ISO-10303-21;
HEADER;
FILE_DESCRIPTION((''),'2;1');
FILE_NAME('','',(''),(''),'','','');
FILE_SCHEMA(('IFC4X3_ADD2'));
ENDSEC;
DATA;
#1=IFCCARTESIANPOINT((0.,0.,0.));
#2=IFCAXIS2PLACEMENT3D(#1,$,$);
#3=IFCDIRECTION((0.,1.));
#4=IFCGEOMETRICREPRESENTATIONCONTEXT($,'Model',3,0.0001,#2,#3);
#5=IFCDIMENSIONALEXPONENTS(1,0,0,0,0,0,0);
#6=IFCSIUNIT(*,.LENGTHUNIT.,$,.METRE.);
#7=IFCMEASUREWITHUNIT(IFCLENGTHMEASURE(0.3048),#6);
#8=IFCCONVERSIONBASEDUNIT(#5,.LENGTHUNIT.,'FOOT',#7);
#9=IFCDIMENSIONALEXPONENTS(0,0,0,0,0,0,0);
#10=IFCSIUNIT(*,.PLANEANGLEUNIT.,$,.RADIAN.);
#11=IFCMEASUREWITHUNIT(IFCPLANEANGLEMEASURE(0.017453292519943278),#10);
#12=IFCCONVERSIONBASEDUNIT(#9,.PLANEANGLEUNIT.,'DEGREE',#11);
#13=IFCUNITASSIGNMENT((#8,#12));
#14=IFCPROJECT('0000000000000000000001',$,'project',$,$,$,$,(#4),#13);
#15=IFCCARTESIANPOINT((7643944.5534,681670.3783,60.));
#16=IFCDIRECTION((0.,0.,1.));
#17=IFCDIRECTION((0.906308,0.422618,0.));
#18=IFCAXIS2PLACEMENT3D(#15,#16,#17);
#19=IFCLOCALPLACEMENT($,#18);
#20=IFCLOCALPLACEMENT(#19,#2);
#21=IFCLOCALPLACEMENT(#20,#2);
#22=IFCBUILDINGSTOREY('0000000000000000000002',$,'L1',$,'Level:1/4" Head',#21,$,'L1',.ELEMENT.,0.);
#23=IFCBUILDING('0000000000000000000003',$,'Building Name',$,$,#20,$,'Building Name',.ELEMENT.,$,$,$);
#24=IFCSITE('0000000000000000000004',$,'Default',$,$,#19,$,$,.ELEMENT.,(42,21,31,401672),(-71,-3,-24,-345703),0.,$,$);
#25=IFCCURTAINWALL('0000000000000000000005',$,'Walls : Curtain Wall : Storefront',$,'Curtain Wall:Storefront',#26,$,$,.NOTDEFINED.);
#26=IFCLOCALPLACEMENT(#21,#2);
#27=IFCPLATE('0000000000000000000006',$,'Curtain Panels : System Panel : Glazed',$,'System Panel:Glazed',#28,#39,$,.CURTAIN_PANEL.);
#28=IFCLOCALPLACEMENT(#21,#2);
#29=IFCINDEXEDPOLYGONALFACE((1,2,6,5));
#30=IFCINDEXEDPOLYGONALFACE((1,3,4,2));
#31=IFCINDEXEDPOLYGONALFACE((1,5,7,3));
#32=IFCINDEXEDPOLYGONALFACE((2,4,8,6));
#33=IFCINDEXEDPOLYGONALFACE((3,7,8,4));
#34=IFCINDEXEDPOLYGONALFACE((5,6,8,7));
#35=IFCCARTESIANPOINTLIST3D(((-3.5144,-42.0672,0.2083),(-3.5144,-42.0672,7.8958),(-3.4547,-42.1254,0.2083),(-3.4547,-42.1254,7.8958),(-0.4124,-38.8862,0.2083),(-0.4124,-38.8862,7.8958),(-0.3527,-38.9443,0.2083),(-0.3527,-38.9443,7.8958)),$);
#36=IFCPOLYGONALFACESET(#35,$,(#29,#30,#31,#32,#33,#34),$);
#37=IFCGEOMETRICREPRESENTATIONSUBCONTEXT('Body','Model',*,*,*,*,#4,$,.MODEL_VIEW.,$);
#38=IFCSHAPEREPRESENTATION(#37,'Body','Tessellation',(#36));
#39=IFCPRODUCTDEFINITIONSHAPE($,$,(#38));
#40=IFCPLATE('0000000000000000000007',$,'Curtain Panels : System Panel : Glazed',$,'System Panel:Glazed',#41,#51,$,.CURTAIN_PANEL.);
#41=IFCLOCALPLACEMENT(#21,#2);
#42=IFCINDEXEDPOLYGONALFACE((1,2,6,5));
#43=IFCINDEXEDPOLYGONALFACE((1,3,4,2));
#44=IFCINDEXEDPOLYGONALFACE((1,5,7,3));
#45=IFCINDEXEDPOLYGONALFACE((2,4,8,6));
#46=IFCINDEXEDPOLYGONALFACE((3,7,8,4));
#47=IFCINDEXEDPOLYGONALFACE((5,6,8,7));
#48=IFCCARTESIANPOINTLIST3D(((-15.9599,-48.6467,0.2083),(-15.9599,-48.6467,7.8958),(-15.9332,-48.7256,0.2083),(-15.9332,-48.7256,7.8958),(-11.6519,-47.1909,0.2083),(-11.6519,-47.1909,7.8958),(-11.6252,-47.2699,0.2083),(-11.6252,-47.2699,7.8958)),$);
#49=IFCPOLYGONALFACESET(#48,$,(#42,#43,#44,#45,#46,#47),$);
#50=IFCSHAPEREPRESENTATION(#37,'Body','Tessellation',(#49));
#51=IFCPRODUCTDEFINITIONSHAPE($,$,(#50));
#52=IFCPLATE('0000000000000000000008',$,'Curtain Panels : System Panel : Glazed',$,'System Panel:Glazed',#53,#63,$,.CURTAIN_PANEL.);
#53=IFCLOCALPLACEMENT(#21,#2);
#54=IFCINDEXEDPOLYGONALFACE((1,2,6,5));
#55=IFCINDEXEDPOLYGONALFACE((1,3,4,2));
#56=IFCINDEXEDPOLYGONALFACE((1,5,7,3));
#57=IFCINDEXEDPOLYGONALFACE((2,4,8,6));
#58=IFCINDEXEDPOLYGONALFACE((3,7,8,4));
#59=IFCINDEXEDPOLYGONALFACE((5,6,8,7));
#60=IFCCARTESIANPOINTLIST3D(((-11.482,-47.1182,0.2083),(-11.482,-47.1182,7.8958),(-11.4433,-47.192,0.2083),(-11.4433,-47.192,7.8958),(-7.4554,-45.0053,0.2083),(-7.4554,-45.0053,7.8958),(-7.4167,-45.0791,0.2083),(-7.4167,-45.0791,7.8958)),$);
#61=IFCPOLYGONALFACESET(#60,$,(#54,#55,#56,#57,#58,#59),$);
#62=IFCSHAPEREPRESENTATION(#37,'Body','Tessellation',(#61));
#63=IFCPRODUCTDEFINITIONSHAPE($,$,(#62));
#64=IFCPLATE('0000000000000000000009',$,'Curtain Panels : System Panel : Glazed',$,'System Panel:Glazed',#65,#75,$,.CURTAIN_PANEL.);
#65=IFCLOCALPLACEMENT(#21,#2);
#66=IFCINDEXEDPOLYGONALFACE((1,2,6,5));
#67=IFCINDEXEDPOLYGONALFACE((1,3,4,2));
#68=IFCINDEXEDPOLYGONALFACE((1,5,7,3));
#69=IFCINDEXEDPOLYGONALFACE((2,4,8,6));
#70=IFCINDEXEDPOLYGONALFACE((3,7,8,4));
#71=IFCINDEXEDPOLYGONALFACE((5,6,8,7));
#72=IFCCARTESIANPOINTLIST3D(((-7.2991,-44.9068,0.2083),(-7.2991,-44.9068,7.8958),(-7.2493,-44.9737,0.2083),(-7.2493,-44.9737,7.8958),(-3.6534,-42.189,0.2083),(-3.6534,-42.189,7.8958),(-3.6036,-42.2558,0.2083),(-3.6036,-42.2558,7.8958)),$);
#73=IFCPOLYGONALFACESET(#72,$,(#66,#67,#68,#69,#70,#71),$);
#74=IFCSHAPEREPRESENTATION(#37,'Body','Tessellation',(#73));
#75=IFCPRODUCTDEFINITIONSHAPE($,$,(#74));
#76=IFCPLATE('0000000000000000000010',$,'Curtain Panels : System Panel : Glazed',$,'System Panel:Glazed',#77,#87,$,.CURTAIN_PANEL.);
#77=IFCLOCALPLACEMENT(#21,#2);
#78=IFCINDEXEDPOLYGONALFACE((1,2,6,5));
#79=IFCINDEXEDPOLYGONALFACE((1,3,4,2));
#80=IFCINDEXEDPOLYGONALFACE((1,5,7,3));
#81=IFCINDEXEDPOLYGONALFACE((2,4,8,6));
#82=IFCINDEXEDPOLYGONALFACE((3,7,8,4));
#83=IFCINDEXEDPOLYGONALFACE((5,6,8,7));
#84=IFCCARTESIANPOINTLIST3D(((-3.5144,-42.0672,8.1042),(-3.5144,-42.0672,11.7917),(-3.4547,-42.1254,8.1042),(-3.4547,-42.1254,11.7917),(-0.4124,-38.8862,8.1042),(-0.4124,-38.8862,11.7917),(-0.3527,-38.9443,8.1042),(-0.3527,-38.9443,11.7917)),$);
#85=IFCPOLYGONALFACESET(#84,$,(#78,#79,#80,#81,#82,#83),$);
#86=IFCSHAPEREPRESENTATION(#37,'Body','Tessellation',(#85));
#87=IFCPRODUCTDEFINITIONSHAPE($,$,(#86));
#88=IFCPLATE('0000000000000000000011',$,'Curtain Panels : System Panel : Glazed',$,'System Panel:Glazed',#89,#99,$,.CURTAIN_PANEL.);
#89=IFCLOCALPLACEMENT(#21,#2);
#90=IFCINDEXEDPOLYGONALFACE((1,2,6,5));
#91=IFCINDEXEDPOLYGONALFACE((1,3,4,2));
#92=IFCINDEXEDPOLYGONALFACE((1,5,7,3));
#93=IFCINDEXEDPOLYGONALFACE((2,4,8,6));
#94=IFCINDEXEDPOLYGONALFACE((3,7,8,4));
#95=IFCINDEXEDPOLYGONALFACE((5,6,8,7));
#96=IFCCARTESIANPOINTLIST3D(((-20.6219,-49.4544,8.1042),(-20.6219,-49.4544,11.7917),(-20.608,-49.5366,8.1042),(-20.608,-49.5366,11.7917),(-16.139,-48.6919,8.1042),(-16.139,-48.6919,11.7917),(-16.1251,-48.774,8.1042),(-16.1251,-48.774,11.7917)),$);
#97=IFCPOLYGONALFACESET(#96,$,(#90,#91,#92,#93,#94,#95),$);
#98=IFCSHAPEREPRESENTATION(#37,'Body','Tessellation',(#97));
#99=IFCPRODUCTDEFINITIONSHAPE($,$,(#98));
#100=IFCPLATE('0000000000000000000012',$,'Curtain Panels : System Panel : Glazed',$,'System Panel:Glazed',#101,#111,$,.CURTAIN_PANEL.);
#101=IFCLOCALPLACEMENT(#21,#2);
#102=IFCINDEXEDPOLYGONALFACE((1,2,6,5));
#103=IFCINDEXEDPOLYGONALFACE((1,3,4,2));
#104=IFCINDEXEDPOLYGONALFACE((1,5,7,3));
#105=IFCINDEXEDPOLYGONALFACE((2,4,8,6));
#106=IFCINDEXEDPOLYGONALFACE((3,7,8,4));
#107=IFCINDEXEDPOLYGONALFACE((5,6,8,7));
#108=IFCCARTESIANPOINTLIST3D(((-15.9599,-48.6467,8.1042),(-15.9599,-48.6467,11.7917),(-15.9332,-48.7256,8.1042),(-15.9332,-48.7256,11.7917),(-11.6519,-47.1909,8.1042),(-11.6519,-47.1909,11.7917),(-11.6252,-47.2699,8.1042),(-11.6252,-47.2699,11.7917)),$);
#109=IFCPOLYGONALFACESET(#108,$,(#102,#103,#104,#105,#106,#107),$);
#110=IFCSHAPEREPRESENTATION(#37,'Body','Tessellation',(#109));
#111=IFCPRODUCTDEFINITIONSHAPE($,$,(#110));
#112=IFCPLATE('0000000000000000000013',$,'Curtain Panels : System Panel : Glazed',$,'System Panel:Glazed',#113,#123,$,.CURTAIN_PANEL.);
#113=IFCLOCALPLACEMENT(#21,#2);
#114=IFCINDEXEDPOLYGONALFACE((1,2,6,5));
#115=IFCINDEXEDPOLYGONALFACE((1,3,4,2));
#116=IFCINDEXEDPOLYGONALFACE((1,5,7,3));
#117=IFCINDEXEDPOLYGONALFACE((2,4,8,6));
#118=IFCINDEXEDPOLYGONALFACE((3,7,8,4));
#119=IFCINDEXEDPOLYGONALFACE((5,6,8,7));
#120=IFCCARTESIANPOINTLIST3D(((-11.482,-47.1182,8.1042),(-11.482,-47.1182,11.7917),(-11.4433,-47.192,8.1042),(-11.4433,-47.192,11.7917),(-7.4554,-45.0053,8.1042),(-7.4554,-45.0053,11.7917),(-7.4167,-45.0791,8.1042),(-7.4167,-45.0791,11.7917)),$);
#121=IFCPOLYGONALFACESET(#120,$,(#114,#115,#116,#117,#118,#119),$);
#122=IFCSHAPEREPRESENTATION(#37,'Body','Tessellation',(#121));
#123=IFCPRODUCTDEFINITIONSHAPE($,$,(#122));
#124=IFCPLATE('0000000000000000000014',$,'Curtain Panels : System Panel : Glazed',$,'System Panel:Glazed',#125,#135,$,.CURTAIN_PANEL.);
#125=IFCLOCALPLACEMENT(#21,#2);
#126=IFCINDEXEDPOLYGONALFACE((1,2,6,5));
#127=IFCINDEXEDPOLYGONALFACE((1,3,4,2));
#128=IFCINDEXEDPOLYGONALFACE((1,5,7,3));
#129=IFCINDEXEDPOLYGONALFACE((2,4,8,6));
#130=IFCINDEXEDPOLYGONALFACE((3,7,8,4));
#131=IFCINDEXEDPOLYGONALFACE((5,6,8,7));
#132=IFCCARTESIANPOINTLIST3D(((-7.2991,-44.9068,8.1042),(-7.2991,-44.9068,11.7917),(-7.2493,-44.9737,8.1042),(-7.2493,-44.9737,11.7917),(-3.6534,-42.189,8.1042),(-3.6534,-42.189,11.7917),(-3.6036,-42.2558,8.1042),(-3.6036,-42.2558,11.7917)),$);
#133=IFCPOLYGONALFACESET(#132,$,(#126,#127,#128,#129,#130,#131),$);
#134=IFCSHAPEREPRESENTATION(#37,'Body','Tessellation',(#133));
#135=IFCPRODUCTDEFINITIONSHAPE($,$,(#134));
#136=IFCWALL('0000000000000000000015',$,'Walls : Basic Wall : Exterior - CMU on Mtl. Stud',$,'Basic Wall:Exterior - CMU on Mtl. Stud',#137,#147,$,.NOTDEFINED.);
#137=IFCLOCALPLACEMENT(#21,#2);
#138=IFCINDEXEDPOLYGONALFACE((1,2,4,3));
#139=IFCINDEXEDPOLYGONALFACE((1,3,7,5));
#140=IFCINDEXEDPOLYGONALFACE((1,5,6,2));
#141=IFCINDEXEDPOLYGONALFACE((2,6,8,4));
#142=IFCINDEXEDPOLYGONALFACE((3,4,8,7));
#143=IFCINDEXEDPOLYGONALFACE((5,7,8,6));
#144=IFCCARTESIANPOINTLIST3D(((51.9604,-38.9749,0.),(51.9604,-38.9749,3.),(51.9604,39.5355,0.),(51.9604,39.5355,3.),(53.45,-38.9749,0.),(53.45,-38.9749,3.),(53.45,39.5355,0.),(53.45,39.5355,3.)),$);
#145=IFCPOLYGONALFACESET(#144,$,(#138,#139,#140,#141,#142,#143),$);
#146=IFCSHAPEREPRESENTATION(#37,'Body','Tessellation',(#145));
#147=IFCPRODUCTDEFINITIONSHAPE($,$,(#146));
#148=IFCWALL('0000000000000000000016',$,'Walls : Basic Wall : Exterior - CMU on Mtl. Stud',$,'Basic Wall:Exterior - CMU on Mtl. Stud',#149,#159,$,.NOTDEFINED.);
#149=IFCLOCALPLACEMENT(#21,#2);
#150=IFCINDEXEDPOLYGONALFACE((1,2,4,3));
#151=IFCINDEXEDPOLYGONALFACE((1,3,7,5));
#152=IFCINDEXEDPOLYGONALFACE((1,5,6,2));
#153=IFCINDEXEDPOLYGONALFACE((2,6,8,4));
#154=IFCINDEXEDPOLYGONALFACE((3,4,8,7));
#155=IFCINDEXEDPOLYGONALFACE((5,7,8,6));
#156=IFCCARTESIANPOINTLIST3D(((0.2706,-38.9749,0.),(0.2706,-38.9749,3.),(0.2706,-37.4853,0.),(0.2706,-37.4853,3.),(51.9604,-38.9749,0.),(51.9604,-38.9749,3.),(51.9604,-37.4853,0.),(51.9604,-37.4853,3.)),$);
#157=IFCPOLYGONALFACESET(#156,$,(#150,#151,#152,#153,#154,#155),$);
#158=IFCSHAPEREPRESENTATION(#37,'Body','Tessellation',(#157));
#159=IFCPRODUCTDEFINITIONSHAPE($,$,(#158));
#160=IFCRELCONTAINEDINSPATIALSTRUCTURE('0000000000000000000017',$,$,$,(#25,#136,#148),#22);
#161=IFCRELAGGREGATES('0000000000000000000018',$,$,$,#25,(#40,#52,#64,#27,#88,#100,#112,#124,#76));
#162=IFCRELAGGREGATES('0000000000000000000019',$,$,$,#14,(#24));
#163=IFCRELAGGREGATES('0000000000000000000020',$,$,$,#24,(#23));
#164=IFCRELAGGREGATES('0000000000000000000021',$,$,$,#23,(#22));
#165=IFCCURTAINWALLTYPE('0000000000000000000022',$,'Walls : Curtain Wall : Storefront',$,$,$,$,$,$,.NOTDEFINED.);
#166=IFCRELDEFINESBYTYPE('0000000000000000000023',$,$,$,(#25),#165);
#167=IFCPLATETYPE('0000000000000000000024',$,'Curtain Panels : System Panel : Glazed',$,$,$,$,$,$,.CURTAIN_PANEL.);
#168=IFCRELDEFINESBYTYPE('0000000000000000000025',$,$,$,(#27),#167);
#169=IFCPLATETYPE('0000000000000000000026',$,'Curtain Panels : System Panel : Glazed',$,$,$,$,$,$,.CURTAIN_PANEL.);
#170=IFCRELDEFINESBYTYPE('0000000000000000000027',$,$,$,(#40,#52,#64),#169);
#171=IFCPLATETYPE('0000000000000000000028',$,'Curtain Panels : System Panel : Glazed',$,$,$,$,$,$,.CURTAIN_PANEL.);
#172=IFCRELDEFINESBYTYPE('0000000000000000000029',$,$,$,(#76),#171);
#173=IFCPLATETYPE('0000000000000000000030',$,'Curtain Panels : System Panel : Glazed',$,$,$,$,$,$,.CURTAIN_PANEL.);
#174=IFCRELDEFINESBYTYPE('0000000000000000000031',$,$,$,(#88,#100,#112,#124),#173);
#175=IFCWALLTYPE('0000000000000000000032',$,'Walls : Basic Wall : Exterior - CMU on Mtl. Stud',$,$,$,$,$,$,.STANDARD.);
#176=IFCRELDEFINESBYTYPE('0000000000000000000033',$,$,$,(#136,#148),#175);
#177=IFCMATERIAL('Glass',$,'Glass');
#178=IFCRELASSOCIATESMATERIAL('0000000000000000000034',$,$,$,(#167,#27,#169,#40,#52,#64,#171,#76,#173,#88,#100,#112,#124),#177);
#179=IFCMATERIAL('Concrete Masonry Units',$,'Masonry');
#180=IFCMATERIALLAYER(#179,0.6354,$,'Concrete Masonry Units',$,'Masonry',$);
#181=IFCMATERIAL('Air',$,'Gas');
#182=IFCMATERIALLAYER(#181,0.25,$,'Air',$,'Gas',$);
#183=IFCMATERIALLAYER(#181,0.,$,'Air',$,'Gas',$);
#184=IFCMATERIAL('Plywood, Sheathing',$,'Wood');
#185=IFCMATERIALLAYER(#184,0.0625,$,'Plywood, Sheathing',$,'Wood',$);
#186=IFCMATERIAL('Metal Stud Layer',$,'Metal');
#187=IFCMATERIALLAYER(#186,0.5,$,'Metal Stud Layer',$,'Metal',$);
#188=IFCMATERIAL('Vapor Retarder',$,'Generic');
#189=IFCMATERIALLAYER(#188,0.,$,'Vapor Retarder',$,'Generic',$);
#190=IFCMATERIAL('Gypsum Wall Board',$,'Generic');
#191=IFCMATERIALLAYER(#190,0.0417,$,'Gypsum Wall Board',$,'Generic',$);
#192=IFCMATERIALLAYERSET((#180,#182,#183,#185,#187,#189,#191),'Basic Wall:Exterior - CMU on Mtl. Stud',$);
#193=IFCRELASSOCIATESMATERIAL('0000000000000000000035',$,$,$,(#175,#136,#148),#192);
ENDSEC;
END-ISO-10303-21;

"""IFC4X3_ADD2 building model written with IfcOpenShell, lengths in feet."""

from ifc_helpers import new_model, entity, si_unit, converted_unit, direction, frame, frame_2d, origin, place, context, subcontext, project, spatial, rectangle, extrude, source, transform, mapped, material, layer, layer_set, type_object, type_shapes, element, aggregate, save


model = new_model("IFC4X3_ADD2")

# Units and contexts
model_context = context("Model", 3, precision=0.0001, world=origin(), true_north=direction((0.0, 1.0)))
body_context = subcontext(model_context, "Body", "Model", "MODEL_VIEW")
ifc_project = project(units=[converted_unit("LENGTHUNIT", "FOOT", entity("IfcLengthMeasure", 0.3048), si_unit("LENGTHUNIT", "METRE"), dimensions=[1, 0, 0, 0, 0, 0, 0]), converted_unit("PLANEANGLEUNIT", "DEGREE", entity("IfcPlaneAngleMeasure", 0.017453292519943278), si_unit("PLANEANGLEUNIT", "RADIAN"), dimensions=[0, 0, 0, 0, 0, 0, 0])], contexts=[model_context])

# Site, building, storey
site_placement = place(None, frame((7643944.5534, 681670.3783, 60.0), z_axis=(0.0, 0.0, 1.0), x_axis=(0.906308, 0.422618, 0.0)))
site = spatial("IfcSite", under=ifc_project, at=site_placement, Name="Default", CompositionType="ELEMENT", RefLatitude=(42, 21, 31, 401672), RefLongitude=(-71, -3, -24, -345703), RefElevation=0.0)
building_placement = place(site_placement, origin())
building = spatial("IfcBuilding", under=site, at=building_placement, Name="Building Name", LongName="Building Name", CompositionType="ELEMENT")
storey_placement = place(building_placement, origin())
storey = spatial("IfcBuildingStorey", under=building, at=storey_placement, Name="L1", ObjectType="Level:1/4\" Head", LongName="L1", CompositionType="ELEMENT", Elevation=0.0)

# Curtain wall
curtain_wall_type = type_object("IfcCurtainWallType", Name="Walls : Curtain Wall : Storefront", PredefinedType="NOTDEFINED")
curtain_wall_placement = place(storey_placement, origin())
curtain_wall = element("IfcCurtainWall", 1, at=curtain_wall_placement, inside=storey, type_object=curtain_wall_type, Name="Walls : Curtain Wall : Storefront", ObjectType="Curtain Wall:Storefront", PredefinedType="NOTDEFINED")

# Shared definitions
ifc_material_1 = material(Name="Plywood, Sheathing", Category="Wood")

# Plates
ifc_material_2 = material(Name="Glass", Category="Glass")
plate_type_1 = type_object("IfcPlateType", Name="Curtain Panels : System Panel : Glazed", PredefinedType="CURTAIN_PANEL", material=ifc_material_2)
shared_shape_1 = source(origin(), body_context, "Body", "SweptSolid", [
    extrude(rectangle(XDim=0.0833, YDim=4.4431, at=frame_2d((0.0, 0.0), x_axis=(1.0, 0.0))), frame((2.2216, 0.0417, 0.0), z_axis=(0.0, 0.0, 1.0), x_axis=(0.0, 1.0, 0.0)), (0.0, 0.0, 1.0), 7.6875),
])
type_shapes(plate_type_1, [shared_shape_1])
plate_1_placement = place(curtain_wall_placement, frame((-3.4547, -42.1254, 0.2083), z_axis=(0.0, 0.0, 1.0), x_axis=(0.69815, 0.715952, 0.0)))
plate_1 = element("IfcPlate", 2, at=plate_1_placement, type_object=plate_type_1, material=ifc_material_2, Name="Curtain Panels : System Panel : Glazed", ObjectType="System Panel:Glazed", PredefinedType="CURTAIN_PANEL", context=body_context, shape_type="MappedRepresentation", body=[
    mapped(shared_shape_1, transform((0.0, 0.0, 0.0), scale=1.0)),
])
plate_type_2 = type_object("IfcPlateType", Name="Curtain Panels : System Panel : Glazed", PredefinedType="CURTAIN_PANEL", material=ifc_material_2)
shared_shape_2 = source(origin(), body_context, "Body", "SweptSolid", [
    extrude(rectangle(XDim=0.0833, YDim=4.5473, at=frame_2d((0.0, 0.0), x_axis=(1.0, 0.0))), frame((2.2737, 0.0417, 0.0), z_axis=(0.0, 0.0, 1.0), x_axis=(0.0, 1.0, 0.0)), (0.0, 0.0, 1.0), 7.6875),
])
type_shapes(plate_type_2, [shared_shape_2])
plate_2_placement = place(curtain_wall_placement, frame((-15.9332, -48.7256, 0.2083), z_axis=(0.0, 0.0, 1.0), x_axis=(0.947373, 0.320131, 0.0)))
plate_2 = element("IfcPlate", 3, at=plate_2_placement, type_object=plate_type_2, material=ifc_material_2, Name="Curtain Panels : System Panel : Glazed", ObjectType="System Panel:Glazed", PredefinedType="CURTAIN_PANEL", context=body_context, shape_type="MappedRepresentation", body=[
    mapped(shared_shape_2, transform((0.0, 0.0, 0.0), scale=1.0)),
])
plate_3_placement = place(curtain_wall_placement, frame((-11.4433, -47.192, 0.2083), z_axis=(0.0, 0.0, 1.0), x_axis=(0.885494, 0.464651, 0.0)))
plate_3 = element("IfcPlate", 4, at=plate_3_placement, type_object=plate_type_2, material=ifc_material_2, Name="Curtain Panels : System Panel : Glazed", ObjectType="System Panel:Glazed", PredefinedType="CURTAIN_PANEL", context=body_context, shape_type="MappedRepresentation", body=[
    mapped(shared_shape_2, transform((0.0, 0.0, 0.0), scale=1.0)),
])
plate_4_placement = place(curtain_wall_placement, frame((-7.2493, -44.9737, 0.2083), z_axis=(0.0, 0.0, 1.0), x_axis=(0.801729, 0.597687, 0.0)))
plate_4 = element("IfcPlate", 5, at=plate_4_placement, type_object=plate_type_2, material=ifc_material_2, Name="Curtain Panels : System Panel : Glazed", ObjectType="System Panel:Glazed", PredefinedType="CURTAIN_PANEL", context=body_context, shape_type="MappedRepresentation", body=[
    mapped(shared_shape_2, transform((0.0, 0.0, 0.0), scale=1.0)),
])
plate_type_3 = type_object("IfcPlateType", Name="Curtain Panels : System Panel : Glazed", PredefinedType="CURTAIN_PANEL", material=ifc_material_2)
shared_shape_3 = source(origin(), body_context, "Body", "SweptSolid", [
    extrude(rectangle(XDim=0.0833, YDim=4.4431, at=frame_2d((0.0, 0.0), x_axis=(1.0, 0.0))), frame((2.2216, 0.0417, 0.0), z_axis=(0.0, 0.0, 1.0), x_axis=(0.0, 1.0, 0.0)), (0.0, 0.0, 1.0), 3.6875),
])
type_shapes(plate_type_3, [shared_shape_3])
plate_5_placement = place(curtain_wall_placement, frame((-3.4547, -42.1254, 8.1042), z_axis=(0.0, 0.0, 1.0), x_axis=(0.69815, 0.715952, 0.0)))
plate_5 = element("IfcPlate", 6, at=plate_5_placement, type_object=plate_type_3, material=ifc_material_2, Name="Curtain Panels : System Panel : Glazed", ObjectType="System Panel:Glazed", PredefinedType="CURTAIN_PANEL", context=body_context, shape_type="MappedRepresentation", body=[
    mapped(shared_shape_3, transform((0.0, 0.0, 0.0), scale=1.0)),
])
plate_type_4 = type_object("IfcPlateType", Name="Curtain Panels : System Panel : Glazed", PredefinedType="CURTAIN_PANEL", material=ifc_material_2)
shared_shape_4 = source(origin(), body_context, "Body", "SweptSolid", [
    extrude(rectangle(XDim=0.0833, YDim=4.5473, at=frame_2d((0.0, 0.0), x_axis=(1.0, 0.0))), frame((2.2737, 0.0417, 0.0), z_axis=(0.0, 0.0, 1.0), x_axis=(0.0, 1.0, 0.0)), (0.0, 0.0, 1.0), 3.6875),
])
type_shapes(plate_type_4, [shared_shape_4])
plate_6_placement = place(curtain_wall_placement, frame((-20.608, -49.5366, 8.1042), z_axis=(0.0, 0.0, 1.0), x_axis=(0.985838, 0.167698, 0.0)))
plate_6 = element("IfcPlate", 7, at=plate_6_placement, type_object=plate_type_4, material=ifc_material_2, Name="Curtain Panels : System Panel : Glazed", ObjectType="System Panel:Glazed", PredefinedType="CURTAIN_PANEL", context=body_context, shape_type="MappedRepresentation", body=[
    mapped(shared_shape_4, transform((0.0, 0.0, 0.0), scale=1.0)),
])
plate_7_placement = place(curtain_wall_placement, frame((-15.9332, -48.7256, 8.1042), z_axis=(0.0, 0.0, 1.0), x_axis=(0.947373, 0.320131, 0.0)))
plate_7 = element("IfcPlate", 8, at=plate_7_placement, type_object=plate_type_4, material=ifc_material_2, Name="Curtain Panels : System Panel : Glazed", ObjectType="System Panel:Glazed", PredefinedType="CURTAIN_PANEL", context=body_context, shape_type="MappedRepresentation", body=[
    mapped(shared_shape_4, transform((0.0, 0.0, 0.0), scale=1.0)),
])
plate_8_placement = place(curtain_wall_placement, frame((-11.4433, -47.192, 8.1042), z_axis=(0.0, 0.0, 1.0), x_axis=(0.885494, 0.464651, 0.0)))
plate_8 = element("IfcPlate", 9, at=plate_8_placement, type_object=plate_type_4, material=ifc_material_2, Name="Curtain Panels : System Panel : Glazed", ObjectType="System Panel:Glazed", PredefinedType="CURTAIN_PANEL", context=body_context, shape_type="MappedRepresentation", body=[
    mapped(shared_shape_4, transform((0.0, 0.0, 0.0), scale=1.0)),
])
plate_9_placement = place(curtain_wall_placement, frame((-7.2493, -44.9737, 8.1042), z_axis=(0.0, 0.0, 1.0), x_axis=(0.801729, 0.597687, 0.0)))
plate_9 = element("IfcPlate", 10, at=plate_9_placement, type_object=plate_type_4, material=ifc_material_2, Name="Curtain Panels : System Panel : Glazed", ObjectType="System Panel:Glazed", PredefinedType="CURTAIN_PANEL", context=body_context, shape_type="MappedRepresentation", body=[
    mapped(shared_shape_4, transform((0.0, 0.0, 0.0), scale=1.0)),
])
aggregate(curtain_wall, [plate_2, plate_3, plate_4, plate_1, plate_6, plate_7, plate_8, plate_9, plate_5])

# Walls
ifc_material_3 = material(Name="Concrete Masonry Units", Category="Masonry")
ifc_layer_1 = layer(ifc_material_3, 0.6354, Name="Concrete Masonry Units", Category="Masonry")
ifc_material_4 = material(Name="Air", Category="Gas")
ifc_layer_2 = layer(ifc_material_4, 0.25, Name="Air", Category="Gas")
ifc_layer_3 = layer(ifc_material_4, 0.0, Name="Air", Category="Gas")
ifc_layer_4 = layer(ifc_material_1, 0.0625, Name="Plywood, Sheathing", Category="Wood")
ifc_material_5 = material(Name="Metal Stud Layer", Category="Metal")
ifc_layer_5 = layer(ifc_material_5, 0.5, Name="Metal Stud Layer", Category="Metal")
ifc_material_6 = material(Name="Vapor Retarder", Category="Generic")
ifc_layer_6 = layer(ifc_material_6, 0.0, Name="Vapor Retarder", Category="Generic")
ifc_material_7 = material(Name="Gypsum Wall Board", Category="Generic")
ifc_layer_7 = layer(ifc_material_7, 0.0417, Name="Gypsum Wall Board", Category="Generic")
ifc_layer_set_1 = layer_set([ifc_layer_1, ifc_layer_2, ifc_layer_3, ifc_layer_4, ifc_layer_5, ifc_layer_6, ifc_layer_7], Name="Basic Wall:Exterior - CMU on Mtl. Stud")
wall_type_1 = type_object("IfcWallType", Name="Walls : Basic Wall : Exterior - CMU on Mtl. Stud", PredefinedType="STANDARD", material=ifc_layer_set_1)
wall_1_placement = place(storey_placement, frame((52.7052, 39.5355, 0.0), z_axis=(0.0, 0.0, 1.0), x_axis=(0.0, -1.0, 0.0)))
element("IfcWall", 11, at=wall_1_placement, inside=storey, type_object=wall_type_1, material=ifc_layer_set_1, Name="Walls : Basic Wall : Exterior - CMU on Mtl. Stud", ObjectType="Basic Wall:Exterior - CMU on Mtl. Stud", PredefinedType="NOTDEFINED", context=body_context, shape_type="SweptSolid", body=[
    extrude(rectangle(XDim=78.5104, YDim=1.4896, at=frame_2d((39.2552, 0.0), x_axis=(-1.0, 0.0))), origin(), (0.0, 0.0, 1.0), 3.0),
])
wall_2_placement = place(storey_placement, frame((51.9604, -38.2301, 0.0), z_axis=(0.0, 0.0, 1.0), x_axis=(-1.0, 0.0, 0.0)))
element("IfcWall", 12, at=wall_2_placement, inside=storey, type_object=wall_type_1, material=ifc_layer_set_1, Name="Walls : Basic Wall : Exterior - CMU on Mtl. Stud", ObjectType="Basic Wall:Exterior - CMU on Mtl. Stud", PredefinedType="NOTDEFINED", context=body_context, shape_type="SweptSolid", body=[
    extrude(rectangle(XDim=51.6898, YDim=1.4896, at=frame_2d((25.8449, 0.0), x_axis=(-1.0, 0.0))), origin(), (0.0, 0.0, 1.0), 3.0),
])

save(model, "model.ifc")
